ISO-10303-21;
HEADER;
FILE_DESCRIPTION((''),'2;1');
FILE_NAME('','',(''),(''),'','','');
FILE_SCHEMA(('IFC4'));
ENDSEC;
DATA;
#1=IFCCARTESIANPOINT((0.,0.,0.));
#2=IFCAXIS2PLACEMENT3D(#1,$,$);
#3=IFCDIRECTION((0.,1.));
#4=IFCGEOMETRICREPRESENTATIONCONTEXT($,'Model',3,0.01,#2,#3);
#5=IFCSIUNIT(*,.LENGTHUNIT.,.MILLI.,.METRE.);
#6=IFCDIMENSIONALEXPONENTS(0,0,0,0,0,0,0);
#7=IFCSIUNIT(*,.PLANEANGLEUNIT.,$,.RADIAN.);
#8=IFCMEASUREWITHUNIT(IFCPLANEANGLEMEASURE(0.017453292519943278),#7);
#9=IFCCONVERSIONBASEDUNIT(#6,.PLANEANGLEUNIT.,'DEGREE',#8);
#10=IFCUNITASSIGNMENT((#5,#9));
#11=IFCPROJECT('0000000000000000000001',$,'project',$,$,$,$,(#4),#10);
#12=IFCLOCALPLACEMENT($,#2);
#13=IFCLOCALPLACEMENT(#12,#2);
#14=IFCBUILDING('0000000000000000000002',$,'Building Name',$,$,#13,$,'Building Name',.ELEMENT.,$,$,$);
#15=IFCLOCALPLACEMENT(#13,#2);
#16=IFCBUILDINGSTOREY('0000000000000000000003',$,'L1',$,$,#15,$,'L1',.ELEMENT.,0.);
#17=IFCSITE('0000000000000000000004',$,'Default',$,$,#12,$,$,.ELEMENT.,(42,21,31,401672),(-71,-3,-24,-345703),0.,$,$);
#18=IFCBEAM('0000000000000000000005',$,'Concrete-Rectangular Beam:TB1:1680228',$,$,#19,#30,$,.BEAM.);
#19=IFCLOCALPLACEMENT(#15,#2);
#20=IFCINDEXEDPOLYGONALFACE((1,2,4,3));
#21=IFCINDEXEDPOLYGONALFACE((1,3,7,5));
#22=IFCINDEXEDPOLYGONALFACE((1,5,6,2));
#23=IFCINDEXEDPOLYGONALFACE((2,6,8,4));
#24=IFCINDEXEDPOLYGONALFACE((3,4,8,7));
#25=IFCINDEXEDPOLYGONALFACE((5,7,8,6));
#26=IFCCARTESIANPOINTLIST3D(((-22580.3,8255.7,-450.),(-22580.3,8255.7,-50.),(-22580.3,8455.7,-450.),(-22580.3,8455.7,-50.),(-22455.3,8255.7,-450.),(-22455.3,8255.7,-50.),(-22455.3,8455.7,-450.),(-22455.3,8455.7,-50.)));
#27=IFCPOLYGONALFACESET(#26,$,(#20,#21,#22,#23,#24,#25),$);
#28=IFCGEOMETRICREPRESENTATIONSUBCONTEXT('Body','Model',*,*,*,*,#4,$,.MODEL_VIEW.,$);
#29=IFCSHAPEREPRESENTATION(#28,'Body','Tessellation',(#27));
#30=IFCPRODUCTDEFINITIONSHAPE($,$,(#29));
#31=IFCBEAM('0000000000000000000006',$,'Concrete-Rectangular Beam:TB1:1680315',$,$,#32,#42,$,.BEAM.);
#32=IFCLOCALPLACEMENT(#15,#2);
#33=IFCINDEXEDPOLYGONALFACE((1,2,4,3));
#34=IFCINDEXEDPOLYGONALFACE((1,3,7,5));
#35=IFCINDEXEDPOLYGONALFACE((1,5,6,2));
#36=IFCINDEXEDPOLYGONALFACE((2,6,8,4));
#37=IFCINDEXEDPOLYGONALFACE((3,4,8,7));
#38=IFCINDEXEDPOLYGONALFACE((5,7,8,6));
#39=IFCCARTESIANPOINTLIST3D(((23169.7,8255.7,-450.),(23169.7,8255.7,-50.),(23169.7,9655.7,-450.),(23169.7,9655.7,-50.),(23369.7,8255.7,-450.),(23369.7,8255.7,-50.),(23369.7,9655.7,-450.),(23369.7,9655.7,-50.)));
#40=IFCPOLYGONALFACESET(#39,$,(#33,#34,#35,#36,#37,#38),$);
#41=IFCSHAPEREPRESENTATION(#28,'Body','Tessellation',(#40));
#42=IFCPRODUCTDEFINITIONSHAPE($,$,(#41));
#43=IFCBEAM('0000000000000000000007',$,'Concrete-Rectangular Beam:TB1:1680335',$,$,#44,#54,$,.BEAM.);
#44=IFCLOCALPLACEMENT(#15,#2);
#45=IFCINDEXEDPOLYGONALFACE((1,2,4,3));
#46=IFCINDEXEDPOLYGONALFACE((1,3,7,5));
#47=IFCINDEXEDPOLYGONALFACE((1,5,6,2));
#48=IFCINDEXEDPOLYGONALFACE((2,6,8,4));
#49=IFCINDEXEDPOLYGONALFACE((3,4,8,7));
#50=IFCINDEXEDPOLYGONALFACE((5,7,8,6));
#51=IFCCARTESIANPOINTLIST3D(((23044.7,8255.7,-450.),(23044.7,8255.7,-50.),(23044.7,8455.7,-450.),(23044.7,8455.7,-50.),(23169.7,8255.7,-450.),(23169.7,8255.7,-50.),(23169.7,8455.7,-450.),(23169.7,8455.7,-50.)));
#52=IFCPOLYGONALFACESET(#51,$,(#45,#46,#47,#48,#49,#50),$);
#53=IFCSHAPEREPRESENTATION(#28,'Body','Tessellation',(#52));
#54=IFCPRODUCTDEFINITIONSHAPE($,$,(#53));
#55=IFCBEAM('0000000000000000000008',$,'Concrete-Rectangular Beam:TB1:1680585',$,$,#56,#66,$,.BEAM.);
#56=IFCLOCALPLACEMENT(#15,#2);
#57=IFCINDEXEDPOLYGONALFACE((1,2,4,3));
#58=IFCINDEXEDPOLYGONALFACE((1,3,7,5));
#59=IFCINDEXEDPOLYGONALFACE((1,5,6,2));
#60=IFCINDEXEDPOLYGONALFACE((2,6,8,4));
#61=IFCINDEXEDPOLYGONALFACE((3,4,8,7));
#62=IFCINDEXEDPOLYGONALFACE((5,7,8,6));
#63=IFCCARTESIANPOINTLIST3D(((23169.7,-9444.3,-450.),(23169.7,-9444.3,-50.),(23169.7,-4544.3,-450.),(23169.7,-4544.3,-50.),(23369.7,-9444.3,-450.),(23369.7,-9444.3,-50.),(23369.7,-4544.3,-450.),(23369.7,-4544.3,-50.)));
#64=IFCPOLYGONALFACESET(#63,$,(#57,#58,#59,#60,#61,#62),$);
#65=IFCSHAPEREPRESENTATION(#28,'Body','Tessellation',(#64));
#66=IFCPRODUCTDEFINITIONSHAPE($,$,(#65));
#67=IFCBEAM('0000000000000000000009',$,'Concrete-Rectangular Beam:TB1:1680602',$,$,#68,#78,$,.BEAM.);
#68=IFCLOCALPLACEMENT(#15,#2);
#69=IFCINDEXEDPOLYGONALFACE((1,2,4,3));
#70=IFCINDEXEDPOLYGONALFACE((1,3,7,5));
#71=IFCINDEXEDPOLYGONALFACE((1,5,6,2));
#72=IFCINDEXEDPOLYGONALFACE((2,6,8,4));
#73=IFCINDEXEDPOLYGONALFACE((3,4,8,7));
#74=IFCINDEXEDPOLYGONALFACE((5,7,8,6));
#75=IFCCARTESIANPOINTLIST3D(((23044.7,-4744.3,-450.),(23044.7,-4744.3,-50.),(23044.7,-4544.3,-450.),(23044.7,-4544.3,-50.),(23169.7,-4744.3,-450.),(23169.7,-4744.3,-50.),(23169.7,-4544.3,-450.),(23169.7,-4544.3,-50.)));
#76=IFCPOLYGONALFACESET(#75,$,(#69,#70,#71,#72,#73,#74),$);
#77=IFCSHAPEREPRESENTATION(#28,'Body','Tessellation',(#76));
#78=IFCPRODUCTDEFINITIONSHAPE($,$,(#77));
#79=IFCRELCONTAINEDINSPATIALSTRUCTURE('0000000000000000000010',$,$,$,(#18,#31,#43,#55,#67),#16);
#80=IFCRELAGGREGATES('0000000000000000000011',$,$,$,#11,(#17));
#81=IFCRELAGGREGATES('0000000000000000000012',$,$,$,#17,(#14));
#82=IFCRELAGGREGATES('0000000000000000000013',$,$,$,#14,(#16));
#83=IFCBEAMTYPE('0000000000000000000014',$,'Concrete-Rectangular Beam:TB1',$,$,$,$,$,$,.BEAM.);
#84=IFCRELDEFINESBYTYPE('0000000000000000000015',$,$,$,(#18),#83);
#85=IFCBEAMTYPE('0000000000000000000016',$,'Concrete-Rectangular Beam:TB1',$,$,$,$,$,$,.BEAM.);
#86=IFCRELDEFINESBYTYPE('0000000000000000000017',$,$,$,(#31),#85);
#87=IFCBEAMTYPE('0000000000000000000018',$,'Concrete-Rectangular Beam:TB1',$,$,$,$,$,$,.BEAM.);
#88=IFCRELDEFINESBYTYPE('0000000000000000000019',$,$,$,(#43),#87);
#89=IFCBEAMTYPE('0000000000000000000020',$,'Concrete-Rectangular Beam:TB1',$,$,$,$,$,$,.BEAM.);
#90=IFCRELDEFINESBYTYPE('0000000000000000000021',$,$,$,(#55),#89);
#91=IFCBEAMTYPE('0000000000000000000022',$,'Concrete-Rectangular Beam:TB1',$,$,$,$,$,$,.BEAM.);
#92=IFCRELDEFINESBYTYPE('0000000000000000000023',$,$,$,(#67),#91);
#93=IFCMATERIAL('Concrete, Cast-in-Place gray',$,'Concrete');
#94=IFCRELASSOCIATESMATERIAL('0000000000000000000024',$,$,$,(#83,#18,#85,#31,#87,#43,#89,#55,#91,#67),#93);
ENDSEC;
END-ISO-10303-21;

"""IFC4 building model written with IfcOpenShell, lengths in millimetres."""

from ifc_helpers import new_model, entity, si_unit, converted_unit, direction, frame, origin, place, context, subcontext, project, spatial, indexed_curve, outline, extrude, source, transform, mapped, material, type_object, type_shapes, element, save


model = new_model("IFC4")

# Units and contexts
model_context = context("Model", 3, precision=0.01, world=origin(), true_north=direction((0.0, 1.0)))
body_context = subcontext(model_context, "Body", "Model", "MODEL_VIEW")
ifc_project = project(units=[si_unit("LENGTHUNIT", "METRE", prefix="MILLI"), converted_unit("PLANEANGLEUNIT", "DEGREE", entity("IfcPlaneAngleMeasure", 0.017453292519943278), si_unit("PLANEANGLEUNIT", "RADIAN"), dimensions=[0, 0, 0, 0, 0, 0, 0])], contexts=[model_context])

# Site, building, storey
site_placement = place(None, origin())
site = spatial("IfcSite", under=ifc_project, at=site_placement, Name="Default", CompositionType="ELEMENT", RefLatitude=(42, 21, 31, 401672), RefLongitude=(-71, -3, -24, -345703), RefElevation=0.0)
building_placement = place(site_placement, origin())
building = spatial("IfcBuilding", under=site, at=building_placement, Name="Building Name", LongName="Building Name", CompositionType="ELEMENT")
storey_placement = place(building_placement, origin())
storey = spatial("IfcBuildingStorey", under=building, at=storey_placement, Name="L1", LongName="L1", CompositionType="ELEMENT", Elevation=0.0)

# Shared definitions
ifc_material = material(Name="Concrete, Cast-in-Place gray", Category="Concrete")

# Beams
beam_type_1 = type_object("IfcBeamType", Name="Concrete-Rectangular Beam:TB1", PredefinedType="BEAM", material=ifc_material)
shared_shape_1 = source(origin(), body_context, "Body", "SweptSolid", [
    extrude(outline(indexed_curve([(-200.0, -100.0), (200.0, -100.0), (200.0, 100.0), (-200.0, 100.0), (-200.0, -100.0)], self_intersect=False)), frame((-22455.3, 8355.7, -250.0), z_axis=(-1.0, 0.0, 0.0), x_axis=(0.0, 0.0, -1.0)), (0.0, 0.0, 1.0), 125.0),
])
type_shapes(beam_type_1, [shared_shape_1])
beam_1_placement = place(storey_placement, origin())
element("IfcBeam", 1, at=beam_1_placement, inside=storey, type_object=beam_type_1, material=ifc_material, Name="Concrete-Rectangular Beam:TB1:1680228", PredefinedType="BEAM", context=body_context, shape_type="MappedRepresentation", body=[
    mapped(shared_shape_1, transform((0.0, 0.0, 0.0), scale=1.0)),
])
beam_type_2 = type_object("IfcBeamType", Name="Concrete-Rectangular Beam:TB1", PredefinedType="BEAM", material=ifc_material)
shared_shape_2 = source(origin(), body_context, "Body", "SweptSolid", [
    extrude(outline(indexed_curve([(-100.0, -200.0), (100.0, -200.0), (100.0, 200.0), (-100.0, 200.0), (-100.0, -200.0)], self_intersect=False)), frame((23269.7, 9655.7, -250.0), z_axis=(0.0, -1.0, 0.0), x_axis=(-1.0, 0.0, 0.0)), (0.0, 0.0, 1.0), 1400.0),
])
type_shapes(beam_type_2, [shared_shape_2])
beam_2_placement = place(storey_placement, origin())
element("IfcBeam", 2, at=beam_2_placement, inside=storey, type_object=beam_type_2, material=ifc_material, Name="Concrete-Rectangular Beam:TB1:1680315", PredefinedType="BEAM", context=body_context, shape_type="MappedRepresentation", body=[
    mapped(shared_shape_2, transform((0.0, 0.0, 0.0), scale=1.0)),
])
beam_type_3 = type_object("IfcBeamType", Name="Concrete-Rectangular Beam:TB1", PredefinedType="BEAM", material=ifc_material)
shared_shape_3 = source(origin(), body_context, "Body", "SweptSolid", [
    extrude(outline(indexed_curve([(-200.0, -100.0), (200.0, -100.0), (200.0, 100.0), (-200.0, 100.0), (-200.0, -100.0)], self_intersect=False)), frame((23169.7, 8355.7, -250.0), z_axis=(-1.0, 0.0, 0.0), x_axis=(0.0, 0.0, -1.0)), (0.0, 0.0, 1.0), 125.0),
])
type_shapes(beam_type_3, [shared_shape_3])
beam_3_placement = place(storey_placement, origin())
element("IfcBeam", 3, at=beam_3_placement, inside=storey, type_object=beam_type_3, material=ifc_material, Name="Concrete-Rectangular Beam:TB1:1680335", PredefinedType="BEAM", context=body_context, shape_type="MappedRepresentation", body=[
    mapped(shared_shape_3, transform((0.0, 0.0, 0.0), scale=1.0)),
])
beam_type_4 = type_object("IfcBeamType", Name="Concrete-Rectangular Beam:TB1", PredefinedType="BEAM", material=ifc_material)
shared_shape_4 = source(origin(), body_context, "Body", "SweptSolid", [
    extrude(outline(indexed_curve([(-100.0, -200.0), (100.0, -200.0), (100.0, 200.0), (-100.0, 200.0), (-100.0, -200.0)], self_intersect=False)), frame((23269.7, -9444.3, -250.0), z_axis=(0.0, 1.0, 0.0), x_axis=(-1.0, 0.0, 0.0)), (0.0, 0.0, 1.0), 4900.0),
])
type_shapes(beam_type_4, [shared_shape_4])
beam_4_placement = place(storey_placement, origin())
element("IfcBeam", 4, at=beam_4_placement, inside=storey, type_object=beam_type_4, material=ifc_material, Name="Concrete-Rectangular Beam:TB1:1680585", PredefinedType="BEAM", context=body_context, shape_type="MappedRepresentation", body=[
    mapped(shared_shape_4, transform((0.0, 0.0, 0.0), scale=1.0)),
])
beam_type_5 = type_object("IfcBeamType", Name="Concrete-Rectangular Beam:TB1", PredefinedType="BEAM", material=ifc_material)
shared_shape_5 = source(origin(), body_context, "Body", "SweptSolid", [
    extrude(outline(indexed_curve([(-200.0, -100.0), (200.0, -100.0), (200.0, 100.0), (-200.0, 100.0), (-200.0, -100.0)], self_intersect=False)), frame((23169.7, -4644.3, -250.0), z_axis=(-1.0, 0.0, 0.0), x_axis=(0.0, 0.0, -1.0)), (0.0, 0.0, 1.0), 125.0),
])
type_shapes(beam_type_5, [shared_shape_5])
beam_5_placement = place(storey_placement, origin())
element("IfcBeam", 5, at=beam_5_placement, inside=storey, type_object=beam_type_5, material=ifc_material, Name="Concrete-Rectangular Beam:TB1:1680602", PredefinedType="BEAM", context=body_context, shape_type="MappedRepresentation", body=[
    mapped(shared_shape_5, transform((0.0, 0.0, 0.0), scale=1.0)),
])

save(model, "model.ifc")
